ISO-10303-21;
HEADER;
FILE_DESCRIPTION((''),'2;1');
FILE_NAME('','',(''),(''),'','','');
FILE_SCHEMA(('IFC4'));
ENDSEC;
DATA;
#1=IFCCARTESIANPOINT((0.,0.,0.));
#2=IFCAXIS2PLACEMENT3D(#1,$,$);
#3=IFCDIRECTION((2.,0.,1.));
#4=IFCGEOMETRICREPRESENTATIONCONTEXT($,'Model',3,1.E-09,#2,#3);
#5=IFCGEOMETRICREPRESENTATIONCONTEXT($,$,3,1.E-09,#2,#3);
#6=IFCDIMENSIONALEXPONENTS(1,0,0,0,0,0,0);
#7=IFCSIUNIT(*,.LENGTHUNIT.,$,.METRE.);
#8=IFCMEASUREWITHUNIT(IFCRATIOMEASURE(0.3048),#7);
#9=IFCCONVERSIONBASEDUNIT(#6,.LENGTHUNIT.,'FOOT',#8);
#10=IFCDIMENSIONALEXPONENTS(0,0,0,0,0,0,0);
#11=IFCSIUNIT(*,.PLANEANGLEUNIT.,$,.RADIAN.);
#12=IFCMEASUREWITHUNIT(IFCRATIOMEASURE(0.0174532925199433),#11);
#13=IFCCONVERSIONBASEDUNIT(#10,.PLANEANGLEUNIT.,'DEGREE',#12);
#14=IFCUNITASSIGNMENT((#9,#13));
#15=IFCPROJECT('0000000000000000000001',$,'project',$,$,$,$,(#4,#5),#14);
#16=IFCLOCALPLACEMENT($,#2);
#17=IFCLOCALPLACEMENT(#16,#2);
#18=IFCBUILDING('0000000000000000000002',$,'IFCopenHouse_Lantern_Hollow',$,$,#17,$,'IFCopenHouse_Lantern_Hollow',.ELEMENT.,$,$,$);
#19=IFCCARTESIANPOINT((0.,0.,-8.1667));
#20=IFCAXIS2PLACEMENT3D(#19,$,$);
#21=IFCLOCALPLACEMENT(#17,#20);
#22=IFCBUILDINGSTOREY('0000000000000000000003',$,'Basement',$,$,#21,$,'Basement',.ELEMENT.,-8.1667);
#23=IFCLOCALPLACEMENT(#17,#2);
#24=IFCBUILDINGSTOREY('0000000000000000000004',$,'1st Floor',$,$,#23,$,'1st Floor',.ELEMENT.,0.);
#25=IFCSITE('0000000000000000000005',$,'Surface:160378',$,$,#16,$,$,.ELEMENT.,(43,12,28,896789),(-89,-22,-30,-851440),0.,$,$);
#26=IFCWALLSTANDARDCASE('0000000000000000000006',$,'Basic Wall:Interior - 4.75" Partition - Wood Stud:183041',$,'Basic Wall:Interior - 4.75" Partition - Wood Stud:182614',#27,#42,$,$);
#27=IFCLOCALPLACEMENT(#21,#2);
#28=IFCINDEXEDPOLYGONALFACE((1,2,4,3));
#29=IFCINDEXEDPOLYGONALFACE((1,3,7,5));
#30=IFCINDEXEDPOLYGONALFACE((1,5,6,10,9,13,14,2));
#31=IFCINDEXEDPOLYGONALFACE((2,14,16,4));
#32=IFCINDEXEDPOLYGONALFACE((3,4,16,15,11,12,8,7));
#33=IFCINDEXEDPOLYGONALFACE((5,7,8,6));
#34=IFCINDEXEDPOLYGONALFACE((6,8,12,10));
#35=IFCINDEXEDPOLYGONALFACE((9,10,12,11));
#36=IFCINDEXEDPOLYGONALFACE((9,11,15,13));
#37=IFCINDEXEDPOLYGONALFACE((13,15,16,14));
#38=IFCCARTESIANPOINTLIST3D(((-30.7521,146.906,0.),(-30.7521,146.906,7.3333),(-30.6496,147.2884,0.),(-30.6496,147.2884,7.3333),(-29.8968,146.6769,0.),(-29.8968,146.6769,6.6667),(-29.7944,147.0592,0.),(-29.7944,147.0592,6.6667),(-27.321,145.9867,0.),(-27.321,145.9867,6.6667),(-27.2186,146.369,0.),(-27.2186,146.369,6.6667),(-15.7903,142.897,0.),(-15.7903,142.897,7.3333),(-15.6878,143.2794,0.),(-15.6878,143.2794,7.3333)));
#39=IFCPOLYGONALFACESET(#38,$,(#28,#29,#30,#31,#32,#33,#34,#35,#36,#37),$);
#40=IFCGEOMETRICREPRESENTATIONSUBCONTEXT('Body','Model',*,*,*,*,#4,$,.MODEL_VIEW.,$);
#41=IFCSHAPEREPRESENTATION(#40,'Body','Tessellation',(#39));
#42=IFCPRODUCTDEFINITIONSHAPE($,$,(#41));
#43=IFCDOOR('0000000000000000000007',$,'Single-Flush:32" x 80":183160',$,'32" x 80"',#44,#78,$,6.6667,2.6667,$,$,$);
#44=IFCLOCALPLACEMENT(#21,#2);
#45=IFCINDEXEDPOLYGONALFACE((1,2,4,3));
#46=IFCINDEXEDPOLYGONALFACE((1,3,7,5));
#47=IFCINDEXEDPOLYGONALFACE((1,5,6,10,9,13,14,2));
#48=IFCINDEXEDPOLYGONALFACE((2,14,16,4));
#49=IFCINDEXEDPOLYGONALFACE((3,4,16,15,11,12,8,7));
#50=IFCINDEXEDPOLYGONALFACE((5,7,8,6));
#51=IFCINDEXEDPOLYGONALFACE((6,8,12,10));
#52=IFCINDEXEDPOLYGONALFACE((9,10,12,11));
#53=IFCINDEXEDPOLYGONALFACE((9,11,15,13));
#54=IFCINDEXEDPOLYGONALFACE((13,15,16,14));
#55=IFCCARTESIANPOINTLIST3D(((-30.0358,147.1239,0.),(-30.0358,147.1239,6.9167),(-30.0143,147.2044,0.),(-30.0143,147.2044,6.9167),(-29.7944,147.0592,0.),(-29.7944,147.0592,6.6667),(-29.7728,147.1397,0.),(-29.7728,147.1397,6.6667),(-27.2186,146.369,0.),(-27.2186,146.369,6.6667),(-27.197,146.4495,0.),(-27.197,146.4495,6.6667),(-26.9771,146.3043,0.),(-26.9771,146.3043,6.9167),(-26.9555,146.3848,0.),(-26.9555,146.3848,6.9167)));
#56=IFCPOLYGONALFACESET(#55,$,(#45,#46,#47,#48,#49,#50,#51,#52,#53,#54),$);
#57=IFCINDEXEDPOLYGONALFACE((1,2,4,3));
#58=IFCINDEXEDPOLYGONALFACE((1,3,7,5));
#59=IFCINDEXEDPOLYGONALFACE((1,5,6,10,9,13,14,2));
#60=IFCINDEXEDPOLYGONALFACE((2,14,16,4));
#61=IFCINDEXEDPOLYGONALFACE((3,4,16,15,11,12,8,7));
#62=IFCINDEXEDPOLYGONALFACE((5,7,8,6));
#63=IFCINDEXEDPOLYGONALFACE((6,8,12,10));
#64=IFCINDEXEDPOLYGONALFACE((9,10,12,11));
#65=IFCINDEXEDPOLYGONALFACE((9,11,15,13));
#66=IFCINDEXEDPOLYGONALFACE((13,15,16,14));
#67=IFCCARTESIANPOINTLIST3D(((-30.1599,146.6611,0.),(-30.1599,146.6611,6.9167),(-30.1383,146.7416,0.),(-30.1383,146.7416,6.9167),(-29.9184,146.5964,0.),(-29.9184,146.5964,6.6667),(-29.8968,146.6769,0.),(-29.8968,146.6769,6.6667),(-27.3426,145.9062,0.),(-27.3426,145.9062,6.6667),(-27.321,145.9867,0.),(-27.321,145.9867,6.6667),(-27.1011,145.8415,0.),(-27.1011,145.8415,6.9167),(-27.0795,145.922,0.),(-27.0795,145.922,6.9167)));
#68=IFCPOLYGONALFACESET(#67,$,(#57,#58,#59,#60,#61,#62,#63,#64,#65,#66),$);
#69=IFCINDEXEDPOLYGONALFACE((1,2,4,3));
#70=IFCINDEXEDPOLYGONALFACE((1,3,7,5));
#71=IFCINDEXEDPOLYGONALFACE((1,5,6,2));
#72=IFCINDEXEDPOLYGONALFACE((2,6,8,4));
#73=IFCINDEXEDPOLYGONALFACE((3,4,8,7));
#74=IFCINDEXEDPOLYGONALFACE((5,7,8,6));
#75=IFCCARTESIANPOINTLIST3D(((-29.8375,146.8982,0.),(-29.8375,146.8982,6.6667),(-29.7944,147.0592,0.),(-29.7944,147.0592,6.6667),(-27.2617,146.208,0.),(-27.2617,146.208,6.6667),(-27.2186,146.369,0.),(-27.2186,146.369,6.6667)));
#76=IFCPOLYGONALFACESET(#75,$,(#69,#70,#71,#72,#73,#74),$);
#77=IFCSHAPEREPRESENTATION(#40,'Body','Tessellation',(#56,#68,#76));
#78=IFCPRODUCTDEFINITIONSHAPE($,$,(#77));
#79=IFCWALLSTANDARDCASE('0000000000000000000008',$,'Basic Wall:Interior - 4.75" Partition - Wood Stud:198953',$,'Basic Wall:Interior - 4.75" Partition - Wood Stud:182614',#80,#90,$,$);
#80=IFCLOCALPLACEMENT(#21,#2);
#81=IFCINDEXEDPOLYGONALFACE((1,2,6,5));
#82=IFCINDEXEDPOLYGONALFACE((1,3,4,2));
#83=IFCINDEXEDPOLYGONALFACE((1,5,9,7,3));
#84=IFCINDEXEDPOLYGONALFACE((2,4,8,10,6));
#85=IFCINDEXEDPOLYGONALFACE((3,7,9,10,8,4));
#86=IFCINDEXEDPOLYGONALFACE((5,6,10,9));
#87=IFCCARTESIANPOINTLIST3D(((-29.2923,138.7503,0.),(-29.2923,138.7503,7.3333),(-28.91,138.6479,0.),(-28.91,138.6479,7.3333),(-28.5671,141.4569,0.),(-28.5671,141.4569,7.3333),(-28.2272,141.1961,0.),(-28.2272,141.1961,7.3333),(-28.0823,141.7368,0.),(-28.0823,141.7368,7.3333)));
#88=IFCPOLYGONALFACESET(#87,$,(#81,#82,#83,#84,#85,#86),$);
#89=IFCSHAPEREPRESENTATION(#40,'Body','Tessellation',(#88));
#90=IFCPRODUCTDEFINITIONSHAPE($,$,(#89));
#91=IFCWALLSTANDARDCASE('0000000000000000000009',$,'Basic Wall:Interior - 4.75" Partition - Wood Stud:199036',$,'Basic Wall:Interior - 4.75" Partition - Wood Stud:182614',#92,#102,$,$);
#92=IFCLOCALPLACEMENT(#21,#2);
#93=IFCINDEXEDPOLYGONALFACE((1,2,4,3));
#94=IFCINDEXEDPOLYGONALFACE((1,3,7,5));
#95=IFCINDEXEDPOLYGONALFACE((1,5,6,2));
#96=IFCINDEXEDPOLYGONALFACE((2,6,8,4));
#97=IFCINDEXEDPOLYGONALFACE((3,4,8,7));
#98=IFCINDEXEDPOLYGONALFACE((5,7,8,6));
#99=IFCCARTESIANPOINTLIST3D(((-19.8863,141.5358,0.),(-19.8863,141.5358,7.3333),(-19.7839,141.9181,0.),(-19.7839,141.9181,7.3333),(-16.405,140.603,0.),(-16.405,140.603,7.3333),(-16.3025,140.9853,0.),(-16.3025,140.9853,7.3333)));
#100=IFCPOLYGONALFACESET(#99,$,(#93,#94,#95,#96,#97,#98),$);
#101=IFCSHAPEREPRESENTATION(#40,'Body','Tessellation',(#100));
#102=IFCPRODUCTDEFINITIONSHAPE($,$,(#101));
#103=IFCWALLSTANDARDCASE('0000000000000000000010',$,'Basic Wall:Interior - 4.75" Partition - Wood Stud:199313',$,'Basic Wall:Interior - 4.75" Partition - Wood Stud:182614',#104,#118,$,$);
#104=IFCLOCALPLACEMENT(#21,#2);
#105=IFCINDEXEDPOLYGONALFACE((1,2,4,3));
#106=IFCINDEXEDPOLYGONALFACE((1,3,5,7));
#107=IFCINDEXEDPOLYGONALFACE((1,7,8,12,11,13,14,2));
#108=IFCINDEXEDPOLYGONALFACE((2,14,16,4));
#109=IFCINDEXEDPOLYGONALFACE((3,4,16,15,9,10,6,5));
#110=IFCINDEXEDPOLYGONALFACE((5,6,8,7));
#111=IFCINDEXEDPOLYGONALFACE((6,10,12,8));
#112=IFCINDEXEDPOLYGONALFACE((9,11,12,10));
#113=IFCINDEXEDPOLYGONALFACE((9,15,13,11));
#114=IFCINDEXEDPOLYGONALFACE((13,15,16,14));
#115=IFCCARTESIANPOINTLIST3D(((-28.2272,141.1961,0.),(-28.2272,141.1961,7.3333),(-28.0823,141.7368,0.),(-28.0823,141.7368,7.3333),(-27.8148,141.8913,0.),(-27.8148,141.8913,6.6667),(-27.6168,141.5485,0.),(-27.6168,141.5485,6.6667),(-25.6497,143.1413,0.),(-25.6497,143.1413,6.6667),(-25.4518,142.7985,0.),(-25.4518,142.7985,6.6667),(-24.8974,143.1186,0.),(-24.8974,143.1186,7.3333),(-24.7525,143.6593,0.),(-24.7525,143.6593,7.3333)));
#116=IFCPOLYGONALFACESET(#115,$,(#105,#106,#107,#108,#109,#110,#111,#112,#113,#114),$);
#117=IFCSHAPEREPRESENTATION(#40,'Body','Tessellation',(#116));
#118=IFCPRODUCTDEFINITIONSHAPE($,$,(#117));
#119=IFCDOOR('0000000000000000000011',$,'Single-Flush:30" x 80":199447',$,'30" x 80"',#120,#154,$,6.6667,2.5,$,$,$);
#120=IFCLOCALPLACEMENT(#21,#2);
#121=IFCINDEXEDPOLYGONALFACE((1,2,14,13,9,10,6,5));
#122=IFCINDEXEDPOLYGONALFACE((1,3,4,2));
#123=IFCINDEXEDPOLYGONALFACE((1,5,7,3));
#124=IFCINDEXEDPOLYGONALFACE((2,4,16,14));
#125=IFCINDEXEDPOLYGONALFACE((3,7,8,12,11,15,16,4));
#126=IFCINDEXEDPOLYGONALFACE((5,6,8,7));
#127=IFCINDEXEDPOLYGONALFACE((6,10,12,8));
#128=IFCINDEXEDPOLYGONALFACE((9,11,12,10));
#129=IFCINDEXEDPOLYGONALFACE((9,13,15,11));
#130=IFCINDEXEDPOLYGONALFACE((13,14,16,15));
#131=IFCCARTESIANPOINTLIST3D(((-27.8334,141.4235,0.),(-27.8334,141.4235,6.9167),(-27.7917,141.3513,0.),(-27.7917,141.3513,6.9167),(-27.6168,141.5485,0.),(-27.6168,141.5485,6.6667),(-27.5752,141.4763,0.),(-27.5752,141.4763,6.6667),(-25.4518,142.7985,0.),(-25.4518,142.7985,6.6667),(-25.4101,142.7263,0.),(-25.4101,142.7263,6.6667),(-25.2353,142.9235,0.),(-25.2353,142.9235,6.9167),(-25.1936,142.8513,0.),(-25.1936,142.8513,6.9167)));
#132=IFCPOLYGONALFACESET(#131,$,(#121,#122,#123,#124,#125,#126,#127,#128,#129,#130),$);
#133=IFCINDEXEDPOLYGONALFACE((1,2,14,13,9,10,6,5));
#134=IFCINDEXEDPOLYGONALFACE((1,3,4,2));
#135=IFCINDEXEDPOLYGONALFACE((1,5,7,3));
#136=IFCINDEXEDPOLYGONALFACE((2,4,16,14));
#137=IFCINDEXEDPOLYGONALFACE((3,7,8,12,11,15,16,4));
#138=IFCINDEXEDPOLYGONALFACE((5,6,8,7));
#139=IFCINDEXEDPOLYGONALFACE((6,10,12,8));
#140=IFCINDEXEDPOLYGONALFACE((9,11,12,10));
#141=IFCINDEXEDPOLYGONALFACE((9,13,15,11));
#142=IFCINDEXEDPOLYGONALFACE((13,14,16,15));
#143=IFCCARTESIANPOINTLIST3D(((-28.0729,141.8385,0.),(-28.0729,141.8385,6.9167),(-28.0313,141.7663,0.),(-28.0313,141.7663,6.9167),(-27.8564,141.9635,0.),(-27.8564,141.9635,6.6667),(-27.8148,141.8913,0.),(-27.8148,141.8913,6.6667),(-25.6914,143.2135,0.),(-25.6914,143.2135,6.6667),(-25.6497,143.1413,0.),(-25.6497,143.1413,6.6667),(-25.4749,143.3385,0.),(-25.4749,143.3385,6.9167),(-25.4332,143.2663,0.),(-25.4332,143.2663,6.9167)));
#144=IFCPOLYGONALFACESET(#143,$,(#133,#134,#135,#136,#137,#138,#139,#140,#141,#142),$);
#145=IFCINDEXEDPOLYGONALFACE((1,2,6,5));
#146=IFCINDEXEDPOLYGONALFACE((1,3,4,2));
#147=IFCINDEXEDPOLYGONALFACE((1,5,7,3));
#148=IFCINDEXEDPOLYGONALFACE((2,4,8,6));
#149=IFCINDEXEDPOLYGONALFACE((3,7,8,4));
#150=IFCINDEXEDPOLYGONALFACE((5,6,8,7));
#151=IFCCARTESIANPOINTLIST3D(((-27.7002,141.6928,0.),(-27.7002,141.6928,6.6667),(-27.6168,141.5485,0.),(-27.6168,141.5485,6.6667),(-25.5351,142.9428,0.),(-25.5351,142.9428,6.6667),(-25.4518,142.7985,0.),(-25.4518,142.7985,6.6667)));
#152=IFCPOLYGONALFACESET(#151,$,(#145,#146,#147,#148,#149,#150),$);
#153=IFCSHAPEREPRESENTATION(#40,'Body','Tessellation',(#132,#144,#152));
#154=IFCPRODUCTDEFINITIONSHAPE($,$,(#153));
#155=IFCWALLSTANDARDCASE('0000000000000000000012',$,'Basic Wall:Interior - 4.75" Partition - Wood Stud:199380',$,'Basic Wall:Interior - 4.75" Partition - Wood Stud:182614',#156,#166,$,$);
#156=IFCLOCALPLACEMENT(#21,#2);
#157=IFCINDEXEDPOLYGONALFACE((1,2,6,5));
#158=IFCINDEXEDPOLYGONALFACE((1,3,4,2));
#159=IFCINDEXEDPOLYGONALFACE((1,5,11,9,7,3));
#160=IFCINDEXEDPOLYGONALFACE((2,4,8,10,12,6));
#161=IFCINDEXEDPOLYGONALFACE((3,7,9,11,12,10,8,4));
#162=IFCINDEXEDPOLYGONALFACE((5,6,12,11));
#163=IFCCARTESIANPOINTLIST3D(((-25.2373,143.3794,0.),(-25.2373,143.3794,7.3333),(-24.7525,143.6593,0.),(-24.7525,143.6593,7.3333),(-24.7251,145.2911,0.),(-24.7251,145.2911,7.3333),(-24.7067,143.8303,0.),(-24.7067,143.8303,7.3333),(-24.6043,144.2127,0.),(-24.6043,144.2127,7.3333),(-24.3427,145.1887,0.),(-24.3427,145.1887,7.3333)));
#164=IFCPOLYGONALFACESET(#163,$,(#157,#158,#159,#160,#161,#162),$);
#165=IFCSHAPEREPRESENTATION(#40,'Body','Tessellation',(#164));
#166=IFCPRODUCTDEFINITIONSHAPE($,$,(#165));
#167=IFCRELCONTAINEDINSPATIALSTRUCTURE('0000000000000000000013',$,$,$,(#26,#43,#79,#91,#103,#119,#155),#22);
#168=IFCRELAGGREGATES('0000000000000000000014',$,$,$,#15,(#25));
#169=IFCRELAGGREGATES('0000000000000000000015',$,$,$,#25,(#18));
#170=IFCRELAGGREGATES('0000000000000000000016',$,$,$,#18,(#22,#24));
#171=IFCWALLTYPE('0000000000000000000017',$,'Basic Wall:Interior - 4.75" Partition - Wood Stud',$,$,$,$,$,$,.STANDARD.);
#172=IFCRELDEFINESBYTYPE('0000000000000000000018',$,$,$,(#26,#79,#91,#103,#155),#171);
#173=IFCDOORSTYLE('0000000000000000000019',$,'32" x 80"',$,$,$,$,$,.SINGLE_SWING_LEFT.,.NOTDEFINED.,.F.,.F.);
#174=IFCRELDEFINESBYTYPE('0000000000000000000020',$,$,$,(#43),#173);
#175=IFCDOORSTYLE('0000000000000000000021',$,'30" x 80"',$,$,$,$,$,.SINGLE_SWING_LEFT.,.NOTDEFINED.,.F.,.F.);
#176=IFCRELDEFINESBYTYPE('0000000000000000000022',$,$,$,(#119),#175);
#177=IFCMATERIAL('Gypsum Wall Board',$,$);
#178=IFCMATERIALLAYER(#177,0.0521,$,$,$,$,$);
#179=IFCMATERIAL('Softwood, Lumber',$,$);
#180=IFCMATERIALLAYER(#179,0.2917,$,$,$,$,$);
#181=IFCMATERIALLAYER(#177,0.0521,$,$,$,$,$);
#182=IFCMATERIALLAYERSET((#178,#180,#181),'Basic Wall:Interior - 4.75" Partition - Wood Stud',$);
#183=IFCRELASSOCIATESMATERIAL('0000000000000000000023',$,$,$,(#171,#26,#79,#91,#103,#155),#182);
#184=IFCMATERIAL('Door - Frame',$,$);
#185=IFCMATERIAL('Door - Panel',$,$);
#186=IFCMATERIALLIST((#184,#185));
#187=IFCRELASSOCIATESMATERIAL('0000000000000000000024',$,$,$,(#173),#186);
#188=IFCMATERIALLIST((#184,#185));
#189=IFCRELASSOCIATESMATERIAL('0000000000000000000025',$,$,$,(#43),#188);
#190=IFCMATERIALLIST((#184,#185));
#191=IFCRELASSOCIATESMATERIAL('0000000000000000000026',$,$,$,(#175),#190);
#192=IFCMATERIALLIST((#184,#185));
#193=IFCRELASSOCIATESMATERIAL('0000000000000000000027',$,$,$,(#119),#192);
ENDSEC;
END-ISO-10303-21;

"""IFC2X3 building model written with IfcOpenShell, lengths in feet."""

from ifc_helpers import new_model, entity, si_unit, converted_unit, direction, frame, frame_2d, origin, origin_2d_with_axis, place, context, subcontext, project, spatial, polyline, rectangle, outline, extrude, source, transform, mapped, material, material_list, layer, layer_set, layer_usage, type_object, type_shapes, element, fill, save


model = new_model("IFC2X3")

# Units and contexts
model_context = context("Model", 3, precision=1e-09, world=origin(), true_north=direction((2.0, 0.0, 1.0)))
context_of_model = context(None, 3, precision=1e-09, world=origin(), true_north=direction((2.0, 0.0, 1.0)))
body_context = subcontext(model_context, "Body", "Model", "MODEL_VIEW")
ifc_project = project(units=[converted_unit("LENGTHUNIT", "FOOT", entity("IfcRatioMeasure", 0.3048), si_unit("LENGTHUNIT", "METRE"), dimensions=[1, 0, 0, 0, 0, 0, 0]), converted_unit("PLANEANGLEUNIT", "DEGREE", entity("IfcRatioMeasure", 0.0174532925199433), si_unit("PLANEANGLEUNIT", "RADIAN"), dimensions=[0, 0, 0, 0, 0, 0, 0])], contexts=[model_context, context_of_model])

# Site, building, storey
site_placement = place(None, origin())
site = spatial("IfcSite", under=ifc_project, at=site_placement, Name="Surface:160378", CompositionType="ELEMENT", RefLatitude=(43, 12, 28, 896789), RefLongitude=(-89, -22, -30, -851440), RefElevation=0.0)
building_placement = place(site_placement, origin())
building = spatial("IfcBuilding", under=site, at=building_placement, Name="IFCopenHouse_Lantern_Hollow", LongName="IFCopenHouse_Lantern_Hollow", CompositionType="ELEMENT")
storey_1_placement = place(building_placement, frame((0.0, 0.0, -8.1667)))
storey_1 = spatial("IfcBuildingStorey", under=building, at=storey_1_placement, Name="Basement", LongName="Basement", CompositionType="ELEMENT", Elevation=-8.1667)

# Shared definitions
ifc_material_1 = material(Name="Softwood, Lumber")
ifc_material_2 = material(Name="Gypsum Wall Board")

# Shared definitions
ifc_layer_1 = layer(ifc_material_2, 0.0521)
ifc_layer_2 = layer(ifc_material_1, 0.2917)
ifc_layer_3 = layer(ifc_material_2, 0.0521)
ifc_layer_set_1 = layer_set([ifc_layer_1, ifc_layer_2, ifc_layer_3], Name="Basic Wall:Interior - 4.75\" Partition - Wood Stud")
wall_type_1 = type_object("IfcWallType", Name="Basic Wall:Interior - 4.75\" Partition - Wood Stud", PredefinedType="STANDARD", material=ifc_layer_set_1)

# Wall, opening, door
ifc_layer_usage_1 = layer_usage(ifc_layer_set_1, "AXIS2", "NEGATIVE", 0.1979)
wall_1_placement = place(storey_1_placement, frame((-30.7008, 147.0972, 0.0), z_axis=(0.0, 0.0, 1.0), x_axis=(0.965926, -0.258819, 0.0)))
wall_1 = element("IfcWallStandardCase", 1, at=wall_1_placement, inside=storey_1, type_object=wall_type_1, material=ifc_layer_usage_1, Name="Basic Wall:Interior - 4.75\" Partition - Wood Stud:183041", ObjectType="Basic Wall:Interior - 4.75\" Partition - Wood Stud:182614", context=body_context, shape_type="SweptSolid", body=[
    extrude(rectangle(XDim=15.4896, YDim=0.3958, at=frame_2d((7.7448, 0.0), x_axis=(-1.0, 0.0))), origin(), (0.0, 0.0, 1.0), 7.3333),
])
opening_1_placement = place(wall_1_placement, frame((0.8854, -0.1979, 0.0)))
opening_1 = element("IfcOpeningElement", 2, at=opening_1_placement, cuts=wall_1, ObjectType="Opening", context=body_context, shape_type="SweptSolid", body=[
    extrude(rectangle(XDim=2.6667, YDim=6.6667, at=frame_2d((3.3333, 1.3333), x_axis=(0.0, -1.0))), frame((0.0, 0.0, 0.0), z_axis=(0.0, 1.0, 0.0), x_axis=(0.0, 0.0, 1.0)), (0.0, 0.0, 1.0), 0.3958),
])
ifc_material_3 = material(Name="Door - Frame")
ifc_material_4 = material(Name="Door - Panel")
ifc_material_list_1 = material_list([ifc_material_3, ifc_material_4])
ifc_material_list_2 = material_list([ifc_material_3, ifc_material_4])
door_style_1 = type_object("IfcDoorStyle", Name="32\" x 80\"", ConstructionType="NOTDEFINED", OperationType="SINGLE_SWING_LEFT", ParameterTakesPrecedence=False, Sizeable=False, material=ifc_material_list_2)
shared_shape_1 = source(origin(), body_context, "Body", "SweptSolid", [
    extrude(outline(polyline([(-1.5833, -3.5208), (1.5833, -3.5208), (1.5833, 3.3958), (1.3333, 3.3958), (1.3333, -3.2708), (-1.3333, -3.2708), (-1.3333, 3.3958), (-1.5833, 3.3958), (-1.5833, -3.5208)])), frame((1.3333, 0.4792, 3.3958), z_axis=(0.0, -1.0, 0.0), x_axis=(-1.0, 0.0, 0.0)), (0.0, 0.0, 1.0), 0.0833),
    extrude(outline(polyline([(-3.5208, -1.5833), (3.3958, -1.5833), (3.3958, -1.3333), (-3.2708, -1.3333), (-3.2708, 1.3333), (3.3958, 1.3333), (3.3958, 1.5833), (-3.5208, 1.5833), (-3.5208, -1.5833)])), frame((1.3333, 0.0, 3.3958), z_axis=(0.0, -1.0, 0.0), x_axis=(0.0, 0.0, -1.0)), (0.0, 0.0, 1.0), 0.0833),
    extrude(rectangle(XDim=2.6667, YDim=0.1667, at=origin_2d_with_axis()), frame((1.3333, 0.3125, 0.0)), (0.0, 0.0, 1.0), 6.6667),
])
type_shapes(door_style_1, [shared_shape_1])
door_1_placement = place(storey_1_placement, frame((-29.8968, 146.6769, 0.0), z_axis=(0.0, 0.0, 1.0), x_axis=(0.965926, -0.258819, 0.0)))
door_1 = element("IfcDoor", 3, at=door_1_placement, inside=storey_1, type_object=door_style_1, material=ifc_material_list_1, Name="Single-Flush:32\" x 80\":183160", ObjectType="32\" x 80\"", OverallHeight=6.6667, OverallWidth=2.6667, context=body_context, shape_type="MappedRepresentation", body=[
    mapped(shared_shape_1, transform((0.0, 0.0, 0.0), scale=1.0)),
])
fill(opening_1, door_1)

# Walls
ifc_layer_usage_2 = layer_usage(ifc_layer_set_1, "AXIS2", "NEGATIVE", 0.1979)
wall_2_placement = place(storey_1_placement, frame((-28.2735, 141.7881, 0.0), z_axis=(0.0, 0.0, 1.0), x_axis=(-0.258819, -0.965926, 0.0)))
element("IfcWallStandardCase", 4, at=wall_2_placement, inside=storey_1, type_object=wall_type_1, material=ifc_layer_usage_2, Name="Basic Wall:Interior - 4.75\" Partition - Wood Stud:198953", ObjectType="Basic Wall:Interior - 4.75\" Partition - Wood Stud:182614", context=body_context, shape_type="SweptSolid", body=[
    extrude(outline(polyline([(3.1979, -0.1979), (3.1979, 0.1979), (0.5598, 0.1979), (0.0, 0.1979), (0.3958, -0.1979), (3.1979, -0.1979)])), origin(), (0.0, 0.0, 1.0), 7.3333),
])
ifc_layer_usage_3 = layer_usage(ifc_layer_set_1, "AXIS2", "NEGATIVE", 0.1979)
wall_3_placement = place(storey_1_placement, frame((-19.8351, 141.727, 0.0), z_axis=(0.0, 0.0, 1.0), x_axis=(0.965926, -0.258819, 0.0)))
element("IfcWallStandardCase", 5, at=wall_3_placement, inside=storey_1, type_object=wall_type_1, material=ifc_layer_usage_3, Name="Basic Wall:Interior - 4.75\" Partition - Wood Stud:199036", ObjectType="Basic Wall:Interior - 4.75\" Partition - Wood Stud:182614", context=body_context, shape_type="SweptSolid", body=[
    extrude(rectangle(XDim=3.6042, YDim=0.3958, at=frame_2d((1.8021, 0.0), x_axis=(-1.0, 0.0))), origin(), (0.0, 0.0, 1.0), 7.3333),
])

# Wall, opening, door
ifc_layer_usage_4 = layer_usage(ifc_layer_set_1, "AXIS2", "NEGATIVE", 0.1979)
wall_4_placement = place(storey_1_placement, frame((-28.3262, 141.3675, 0.0), z_axis=(0.0, 0.0, 1.0), x_axis=(0.866025, 0.5, 0.0)))
wall_4 = element("IfcWallStandardCase", 6, at=wall_4_placement, inside=storey_1, type_object=wall_type_1, material=ifc_layer_usage_4, Name="Basic Wall:Interior - 4.75\" Partition - Wood Stud:199313", ObjectType="Basic Wall:Interior - 4.75\" Partition - Wood Stud:182614", context=body_context, shape_type="SweptSolid", body=[
    extrude(outline(polyline([(0.0, -0.1979), (3.8449, -0.1979), (4.2407, 0.1979), (3.6809, 0.1979), (0.3958, 0.1979), (0.0, -0.1979)])), origin(), (0.0, 0.0, 1.0), 7.3333),
])
opening_2_placement = place(wall_4_placement, frame((3.2048, 0.1979, 0.0)))
opening_2 = element("IfcOpeningElement", 7, at=opening_2_placement, cuts=wall_4, ObjectType="Opening", context=body_context, shape_type="SweptSolid", body=[
    extrude(rectangle(XDim=2.5, YDim=6.6667, at=frame_2d((3.3333, 1.25), x_axis=(0.0, -1.0))), frame((0.0, 0.0, 0.0), z_axis=(0.0, -1.0, 0.0), x_axis=(0.0, 0.0, 1.0)), (0.0, 0.0, 1.0), 0.3958),
])
ifc_material_list_3 = material_list([ifc_material_3, ifc_material_4])
ifc_material_list_4 = material_list([ifc_material_3, ifc_material_4])
door_style_2 = type_object("IfcDoorStyle", Name="30\" x 80\"", ConstructionType="NOTDEFINED", OperationType="SINGLE_SWING_LEFT", ParameterTakesPrecedence=False, Sizeable=False, material=ifc_material_list_4)
shared_shape_2 = source(origin(), body_context, "Body", "SweptSolid", [
    extrude(outline(polyline([(-1.5, -3.5208), (1.5, -3.5208), (1.5, 3.3958), (1.25, 3.3958), (1.25, -3.2708), (-1.25, -3.2708), (-1.25, 3.3958), (-1.5, 3.3958), (-1.5, -3.5208)])), frame((1.25, 0.4792, 3.3958), z_axis=(0.0, -1.0, 0.0), x_axis=(-1.0, 0.0, 0.0)), (0.0, 0.0, 1.0), 0.0833),
    extrude(outline(polyline([(-3.5208, -1.5), (3.3958, -1.5), (3.3958, -1.25), (-3.2708, -1.25), (-3.2708, 1.25), (3.3958, 1.25), (3.3958, 1.5), (-3.5208, 1.5), (-3.5208, -1.5)])), frame((1.25, 0.0, 3.3958), z_axis=(0.0, -1.0, 0.0), x_axis=(0.0, 0.0, -1.0)), (0.0, 0.0, 1.0), 0.0833),
    extrude(rectangle(XDim=2.5, YDim=0.1667, at=origin_2d_with_axis()), frame((1.25, 0.3125, 0.0)), (0.0, 0.0, 1.0), 6.6667),
])
type_shapes(door_style_2, [shared_shape_2])
door_2_placement = place(storey_1_placement, frame((-25.6497, 143.1413, 0.0), z_axis=(0.0, 0.0, 1.0), x_axis=(-0.866025, -0.5, 0.0)))
door_2 = element("IfcDoor", 8, at=door_2_placement, inside=storey_1, type_object=door_style_2, material=ifc_material_list_3, Name="Single-Flush:30\" x 80\":199447", ObjectType="30\" x 80\"", OverallHeight=6.6667, OverallWidth=2.5, context=body_context, shape_type="MappedRepresentation", body=[
    mapped(shared_shape_2, transform((0.0, 0.0, 0.0), scale=1.0)),
])
fill(opening_2, door_2)

# Wall
ifc_layer_usage_5 = layer_usage(ifc_layer_set_1, "AXIS2", "NEGATIVE", 0.1979)
wall_5_placement = place(storey_1_placement, frame((-25.0462, 143.3282, 0.0), z_axis=(0.0, 0.0, 1.0), x_axis=(0.258819, 0.965926, 0.0)))
element("IfcWallStandardCase", 9, at=wall_5_placement, inside=storey_1, type_object=wall_type_1, material=ifc_layer_usage_5, Name="Basic Wall:Interior - 4.75\" Partition - Wood Stud:199380", ObjectType="Basic Wall:Interior - 4.75\" Partition - Wood Stud:182614", context=body_context, shape_type="SweptSolid", body=[
    extrude(outline(polyline([(1.9792, -0.1979), (1.9792, 0.1979), (0.0, 0.1979), (0.3958, -0.1979), (0.5729, -0.1979), (0.9688, -0.1979), (1.9792, -0.1979)])), origin(), (0.0, 0.0, 1.0), 7.3333),
])

# Shared definitions
storey_2_placement = place(building_placement, origin())
storey_2 = spatial("IfcBuildingStorey", under=building, at=storey_2_placement, Name="1st Floor", LongName="1st Floor", CompositionType="ELEMENT", Elevation=0.0)

save(model, "model.ifc")
